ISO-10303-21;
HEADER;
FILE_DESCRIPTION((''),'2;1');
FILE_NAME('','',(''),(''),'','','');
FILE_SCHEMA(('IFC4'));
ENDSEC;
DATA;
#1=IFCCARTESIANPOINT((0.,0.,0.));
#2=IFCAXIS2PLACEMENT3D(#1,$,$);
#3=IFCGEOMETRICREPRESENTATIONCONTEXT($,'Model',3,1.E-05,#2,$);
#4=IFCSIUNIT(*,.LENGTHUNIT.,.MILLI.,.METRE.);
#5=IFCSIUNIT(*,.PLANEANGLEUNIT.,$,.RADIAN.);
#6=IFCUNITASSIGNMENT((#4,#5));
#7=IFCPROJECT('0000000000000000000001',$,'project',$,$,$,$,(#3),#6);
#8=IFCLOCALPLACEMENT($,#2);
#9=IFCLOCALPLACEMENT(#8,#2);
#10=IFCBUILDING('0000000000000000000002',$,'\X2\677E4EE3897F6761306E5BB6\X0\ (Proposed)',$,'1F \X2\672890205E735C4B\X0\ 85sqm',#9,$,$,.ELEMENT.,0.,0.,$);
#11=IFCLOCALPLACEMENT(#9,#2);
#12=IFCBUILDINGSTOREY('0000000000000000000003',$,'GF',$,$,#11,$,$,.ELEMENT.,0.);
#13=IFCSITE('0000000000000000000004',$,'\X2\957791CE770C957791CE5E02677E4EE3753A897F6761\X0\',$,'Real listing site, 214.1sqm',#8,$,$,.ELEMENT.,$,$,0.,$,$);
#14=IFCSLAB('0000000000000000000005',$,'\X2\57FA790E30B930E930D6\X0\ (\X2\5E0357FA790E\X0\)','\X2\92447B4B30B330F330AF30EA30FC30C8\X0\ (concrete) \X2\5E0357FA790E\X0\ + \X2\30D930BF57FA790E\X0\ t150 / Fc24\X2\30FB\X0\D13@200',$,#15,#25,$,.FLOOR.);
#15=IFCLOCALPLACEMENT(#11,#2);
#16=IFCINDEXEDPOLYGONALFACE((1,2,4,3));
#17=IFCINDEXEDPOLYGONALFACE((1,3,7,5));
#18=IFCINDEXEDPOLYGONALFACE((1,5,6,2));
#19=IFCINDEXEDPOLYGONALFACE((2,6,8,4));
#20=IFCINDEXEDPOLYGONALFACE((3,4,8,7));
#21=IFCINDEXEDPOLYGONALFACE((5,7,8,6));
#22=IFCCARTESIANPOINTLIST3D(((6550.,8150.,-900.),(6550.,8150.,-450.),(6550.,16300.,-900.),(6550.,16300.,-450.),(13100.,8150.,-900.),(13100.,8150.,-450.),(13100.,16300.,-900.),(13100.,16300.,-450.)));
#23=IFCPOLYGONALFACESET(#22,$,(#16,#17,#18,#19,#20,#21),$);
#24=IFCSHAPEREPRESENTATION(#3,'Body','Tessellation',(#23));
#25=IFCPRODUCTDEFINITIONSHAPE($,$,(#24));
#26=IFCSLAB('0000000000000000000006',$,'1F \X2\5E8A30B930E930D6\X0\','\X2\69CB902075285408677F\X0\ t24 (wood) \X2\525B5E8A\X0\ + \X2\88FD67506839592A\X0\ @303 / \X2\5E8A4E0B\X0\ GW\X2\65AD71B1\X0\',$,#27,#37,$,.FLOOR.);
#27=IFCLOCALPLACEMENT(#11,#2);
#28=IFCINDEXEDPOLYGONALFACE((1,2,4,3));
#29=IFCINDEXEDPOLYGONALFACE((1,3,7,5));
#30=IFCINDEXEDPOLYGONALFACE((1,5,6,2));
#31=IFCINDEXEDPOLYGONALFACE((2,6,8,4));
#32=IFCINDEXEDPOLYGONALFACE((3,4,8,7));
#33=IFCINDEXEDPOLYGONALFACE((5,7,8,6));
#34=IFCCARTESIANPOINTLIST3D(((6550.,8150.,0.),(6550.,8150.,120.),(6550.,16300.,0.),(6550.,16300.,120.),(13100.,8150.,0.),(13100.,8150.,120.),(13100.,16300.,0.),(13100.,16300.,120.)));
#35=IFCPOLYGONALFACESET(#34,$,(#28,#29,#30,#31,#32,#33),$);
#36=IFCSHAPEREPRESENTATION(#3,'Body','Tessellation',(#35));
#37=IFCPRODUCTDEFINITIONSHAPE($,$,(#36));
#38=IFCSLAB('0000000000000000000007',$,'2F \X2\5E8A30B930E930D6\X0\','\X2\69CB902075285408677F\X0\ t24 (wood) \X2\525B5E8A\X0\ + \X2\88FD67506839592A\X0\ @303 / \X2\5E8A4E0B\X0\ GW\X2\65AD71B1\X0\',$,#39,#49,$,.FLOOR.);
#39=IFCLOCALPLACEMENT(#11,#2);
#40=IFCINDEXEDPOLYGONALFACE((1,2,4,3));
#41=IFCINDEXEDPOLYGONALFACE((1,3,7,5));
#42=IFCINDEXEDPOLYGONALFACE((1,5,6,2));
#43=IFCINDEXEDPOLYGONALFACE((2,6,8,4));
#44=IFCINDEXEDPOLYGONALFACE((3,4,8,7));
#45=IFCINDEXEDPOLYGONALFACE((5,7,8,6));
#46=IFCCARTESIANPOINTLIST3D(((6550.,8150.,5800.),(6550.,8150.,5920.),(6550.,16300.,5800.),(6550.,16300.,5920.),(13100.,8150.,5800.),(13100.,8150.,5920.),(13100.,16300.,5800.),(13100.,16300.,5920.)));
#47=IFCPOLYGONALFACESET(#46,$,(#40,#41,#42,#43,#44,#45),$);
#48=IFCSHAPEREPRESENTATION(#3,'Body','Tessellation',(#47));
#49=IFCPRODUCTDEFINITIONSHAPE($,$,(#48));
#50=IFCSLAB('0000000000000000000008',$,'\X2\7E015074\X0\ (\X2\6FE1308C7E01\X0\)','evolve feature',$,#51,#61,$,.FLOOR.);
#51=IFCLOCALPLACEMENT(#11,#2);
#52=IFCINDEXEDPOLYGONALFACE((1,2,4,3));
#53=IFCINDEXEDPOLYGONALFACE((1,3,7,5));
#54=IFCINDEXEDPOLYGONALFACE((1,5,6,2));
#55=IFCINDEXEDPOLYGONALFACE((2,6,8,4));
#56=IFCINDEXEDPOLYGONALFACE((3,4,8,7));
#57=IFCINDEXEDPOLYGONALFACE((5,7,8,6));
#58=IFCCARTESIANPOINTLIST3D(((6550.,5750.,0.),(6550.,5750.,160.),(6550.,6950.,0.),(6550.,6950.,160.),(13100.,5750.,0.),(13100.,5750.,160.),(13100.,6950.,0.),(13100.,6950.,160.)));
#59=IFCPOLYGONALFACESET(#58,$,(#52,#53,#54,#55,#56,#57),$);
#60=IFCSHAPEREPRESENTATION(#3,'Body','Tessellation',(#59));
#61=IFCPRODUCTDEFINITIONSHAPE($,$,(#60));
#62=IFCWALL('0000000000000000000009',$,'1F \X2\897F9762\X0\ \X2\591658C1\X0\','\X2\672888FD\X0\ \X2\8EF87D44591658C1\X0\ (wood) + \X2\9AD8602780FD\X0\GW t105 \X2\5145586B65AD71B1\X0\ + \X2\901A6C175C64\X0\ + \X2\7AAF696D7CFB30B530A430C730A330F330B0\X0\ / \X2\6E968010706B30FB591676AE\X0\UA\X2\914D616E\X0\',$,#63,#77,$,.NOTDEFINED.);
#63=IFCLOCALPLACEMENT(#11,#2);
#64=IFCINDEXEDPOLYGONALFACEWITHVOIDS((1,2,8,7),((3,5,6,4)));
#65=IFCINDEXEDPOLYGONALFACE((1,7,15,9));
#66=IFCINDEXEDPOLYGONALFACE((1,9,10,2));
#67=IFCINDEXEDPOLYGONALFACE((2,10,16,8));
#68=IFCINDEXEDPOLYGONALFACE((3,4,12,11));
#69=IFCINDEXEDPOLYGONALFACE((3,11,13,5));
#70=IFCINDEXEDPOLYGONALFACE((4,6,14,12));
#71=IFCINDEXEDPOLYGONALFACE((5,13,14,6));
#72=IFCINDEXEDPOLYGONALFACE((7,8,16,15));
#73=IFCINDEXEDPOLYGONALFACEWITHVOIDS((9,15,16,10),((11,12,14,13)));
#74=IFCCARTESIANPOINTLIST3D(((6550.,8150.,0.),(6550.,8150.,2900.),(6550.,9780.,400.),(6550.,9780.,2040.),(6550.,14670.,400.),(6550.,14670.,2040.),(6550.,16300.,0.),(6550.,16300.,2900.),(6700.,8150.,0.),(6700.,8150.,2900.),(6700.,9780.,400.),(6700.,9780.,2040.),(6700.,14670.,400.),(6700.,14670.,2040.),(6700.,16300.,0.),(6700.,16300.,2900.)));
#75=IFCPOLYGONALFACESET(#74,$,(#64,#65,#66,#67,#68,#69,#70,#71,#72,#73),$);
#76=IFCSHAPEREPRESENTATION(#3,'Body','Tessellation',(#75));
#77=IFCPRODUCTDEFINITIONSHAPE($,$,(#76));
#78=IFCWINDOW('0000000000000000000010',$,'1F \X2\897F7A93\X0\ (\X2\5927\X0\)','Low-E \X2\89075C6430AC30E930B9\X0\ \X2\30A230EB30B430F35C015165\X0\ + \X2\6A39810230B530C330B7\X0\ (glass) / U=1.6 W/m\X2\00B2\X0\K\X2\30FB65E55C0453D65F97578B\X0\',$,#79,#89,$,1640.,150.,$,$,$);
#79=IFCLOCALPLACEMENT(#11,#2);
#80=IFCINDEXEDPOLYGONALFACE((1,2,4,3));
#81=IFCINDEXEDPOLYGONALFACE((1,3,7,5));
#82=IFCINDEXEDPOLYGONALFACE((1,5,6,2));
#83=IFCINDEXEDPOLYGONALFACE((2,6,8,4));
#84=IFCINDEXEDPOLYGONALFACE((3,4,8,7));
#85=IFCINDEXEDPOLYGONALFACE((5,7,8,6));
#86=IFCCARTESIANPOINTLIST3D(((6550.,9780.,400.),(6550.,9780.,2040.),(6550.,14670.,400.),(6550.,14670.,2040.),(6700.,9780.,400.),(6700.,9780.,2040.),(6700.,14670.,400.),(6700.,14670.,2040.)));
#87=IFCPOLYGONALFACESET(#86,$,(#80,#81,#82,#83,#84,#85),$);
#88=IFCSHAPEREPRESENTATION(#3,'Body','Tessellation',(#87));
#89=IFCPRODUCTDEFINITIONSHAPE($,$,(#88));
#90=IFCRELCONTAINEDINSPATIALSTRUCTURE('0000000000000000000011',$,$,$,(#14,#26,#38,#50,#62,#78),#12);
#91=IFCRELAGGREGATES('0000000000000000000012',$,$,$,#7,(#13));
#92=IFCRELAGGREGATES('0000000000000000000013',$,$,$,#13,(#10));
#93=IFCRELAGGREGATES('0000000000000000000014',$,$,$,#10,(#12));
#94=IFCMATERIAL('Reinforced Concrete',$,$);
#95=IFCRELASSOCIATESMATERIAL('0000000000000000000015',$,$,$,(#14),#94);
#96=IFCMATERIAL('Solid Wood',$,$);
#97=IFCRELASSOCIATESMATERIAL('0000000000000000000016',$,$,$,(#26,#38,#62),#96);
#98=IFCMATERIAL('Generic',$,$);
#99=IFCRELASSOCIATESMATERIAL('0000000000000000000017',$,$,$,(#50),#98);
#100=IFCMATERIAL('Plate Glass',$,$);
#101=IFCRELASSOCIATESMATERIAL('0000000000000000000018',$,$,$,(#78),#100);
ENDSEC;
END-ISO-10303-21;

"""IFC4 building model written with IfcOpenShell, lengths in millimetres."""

from ifc_helpers import new_model, si_unit, frame, frame_2d, origin, place, context, project, spatial, rectangle, extrude, material, element, fill, save


model = new_model("IFC4")

# Units and contexts
model_context = context("Model", 3, precision=1e-05, world=origin())
ifc_project = project(units=[si_unit("LENGTHUNIT", "METRE", prefix="MILLI"), si_unit("PLANEANGLEUNIT", "RADIAN")], contexts=[model_context])

# Site, building, storey
site_placement = place(None, origin())
site = spatial("IfcSite", under=ifc_project, at=site_placement, Name="長野県長野市松代町西条", ObjectType="Real listing site, 214.1sqm", CompositionType="ELEMENT", RefElevation=0.0)
building_placement = place(site_placement, origin())
building = spatial("IfcBuilding", under=site, at=building_placement, Name="松代西条の家 (Proposed)", ObjectType="1F 木造平屋 85sqm", CompositionType="ELEMENT", ElevationOfRefHeight=0.0, ElevationOfTerrain=0.0)
storey_placement = place(building_placement, origin())
storey = spatial("IfcBuildingStorey", under=building, at=storey_placement, Name="GF", CompositionType="ELEMENT", Elevation=0.0)

# Slabs
ifc_material_1 = material(Name="Reinforced Concrete")
slab_1_placement = place(storey_placement, frame((3275.0, 4075.0, -450.0)))
element("IfcSlab", 1, at=slab_1_placement, inside=storey, material=ifc_material_1, Name="基礎スラブ (布基礎)", Description="鉄筋コンクリート (concrete) 布基礎 + ベタ基礎 t150 / Fc24・D13@200", PredefinedType="FLOOR", context=model_context, shape_type="SweptSolid", body=[
    extrude(rectangle(XDim=6550.0, YDim=8150.0, at=frame_2d((3275.0, 4075.0))), frame((3275.0, 4075.0, -450.0)), (0.0, 0.0, 1.0), 450.0),
])
ifc_material_2 = material(Name="Solid Wood")
slab_2_placement = place(storey_placement, frame((3275.0, 4075.0, 0.0)))
element("IfcSlab", 2, at=slab_2_placement, inside=storey, material=ifc_material_2, Name="1F 床スラブ", Description="構造用合板 t24 (wood) 剛床 + 製材根太 @303 / 床下 GW断熱", PredefinedType="FLOOR", context=model_context, shape_type="SweptSolid", body=[
    extrude(rectangle(XDim=6550.0, YDim=8150.0, at=frame_2d((3275.0, 4075.0))), frame((3275.0, 4075.0, 0.0)), (0.0, 0.0, 1.0), 120.0),
])
slab_3_placement = place(storey_placement, frame((3275.0, 4075.0, 2900.0)))
element("IfcSlab", 3, at=slab_3_placement, inside=storey, material=ifc_material_2, Name="2F 床スラブ", Description="構造用合板 t24 (wood) 剛床 + 製材根太 @303 / 床下 GW断熱", PredefinedType="FLOOR", context=model_context, shape_type="SweptSolid", body=[
    extrude(rectangle(XDim=6550.0, YDim=8150.0, at=frame_2d((3275.0, 4075.0))), frame((3275.0, 4075.0, 2900.0)), (0.0, 0.0, 1.0), 120.0),
])
ifc_material_3 = material(Name="Generic")
slab_4_placement = place(storey_placement, frame((3275.0, 2875.0, 0.0)))
element("IfcSlab", 4, at=slab_4_placement, inside=storey, material=ifc_material_3, Name="縁側 (濡れ縁)", Description="evolve feature", PredefinedType="FLOOR", context=model_context, shape_type="SweptSolid", body=[
    extrude(rectangle(XDim=6550.0, YDim=1200.0, at=frame_2d((3275.0, 600.0))), frame((3275.0, 2875.0, 0.0)), (0.0, 0.0, 1.0), 160.0),
])

# Shared definitions
ifc_material_4 = material(Name="Plate Glass")

# Wall, opening, window
wall_1_placement = place(storey_placement, frame((3275.0, 4075.0, 0.0)))
wall_1 = element("IfcWall", 5, at=wall_1_placement, inside=storey, material=ifc_material_2, Name="1F 西面 外壁", Description="木製 軸組外壁 (wood) + 高性能GW t105 充填断熱 + 通気層 + 窯業系サイディング / 準耐火・外皮UA配慮", PredefinedType="NOTDEFINED", context=model_context, shape_type="SweptSolid", body=[
    extrude(rectangle(XDim=150.0, YDim=8150.0, at=frame_2d((75.0, 4075.0))), frame((3275.0, 4075.0, 0.0)), (0.0, 0.0, 1.0), 2900.0),
])
opening_1_placement = place(storey_placement, frame((3275.0, 4890.0, 200.0)))
opening_1 = element("IfcOpeningElement", 6, at=opening_1_placement, cuts=wall_1, PredefinedType="NOTDEFINED", context=model_context, shape_type="SweptSolid", body=[
    extrude(rectangle(XDim=150.0, YDim=4890.0, at=frame_2d((75.0, 2445.0))), frame((3275.0, 4890.0, 200.0)), (0.0, 0.0, 1.0), 1640.0),
])
window_1_placement = place(storey_placement, frame((3275.0, 4890.0, 200.0)))
window_1 = element("IfcWindow", 7, at=window_1_placement, inside=storey, material=ifc_material_4, Name="1F 西窓 (大)", Description="Low-E 複層ガラス アルゴン封入 + 樹脂サッシ (glass) / U=1.6 W/m²K・日射取得型", OverallHeight=1640.0, OverallWidth=150.0, context=model_context, shape_type="SweptSolid", body=[
    extrude(rectangle(XDim=150.0, YDim=4890.0, at=frame_2d((75.0, 2445.0))), frame((3275.0, 4890.0, 200.0)), (0.0, 0.0, 1.0), 1640.0),
])
fill(opening_1, window_1)

save(model, "model.ifc")
